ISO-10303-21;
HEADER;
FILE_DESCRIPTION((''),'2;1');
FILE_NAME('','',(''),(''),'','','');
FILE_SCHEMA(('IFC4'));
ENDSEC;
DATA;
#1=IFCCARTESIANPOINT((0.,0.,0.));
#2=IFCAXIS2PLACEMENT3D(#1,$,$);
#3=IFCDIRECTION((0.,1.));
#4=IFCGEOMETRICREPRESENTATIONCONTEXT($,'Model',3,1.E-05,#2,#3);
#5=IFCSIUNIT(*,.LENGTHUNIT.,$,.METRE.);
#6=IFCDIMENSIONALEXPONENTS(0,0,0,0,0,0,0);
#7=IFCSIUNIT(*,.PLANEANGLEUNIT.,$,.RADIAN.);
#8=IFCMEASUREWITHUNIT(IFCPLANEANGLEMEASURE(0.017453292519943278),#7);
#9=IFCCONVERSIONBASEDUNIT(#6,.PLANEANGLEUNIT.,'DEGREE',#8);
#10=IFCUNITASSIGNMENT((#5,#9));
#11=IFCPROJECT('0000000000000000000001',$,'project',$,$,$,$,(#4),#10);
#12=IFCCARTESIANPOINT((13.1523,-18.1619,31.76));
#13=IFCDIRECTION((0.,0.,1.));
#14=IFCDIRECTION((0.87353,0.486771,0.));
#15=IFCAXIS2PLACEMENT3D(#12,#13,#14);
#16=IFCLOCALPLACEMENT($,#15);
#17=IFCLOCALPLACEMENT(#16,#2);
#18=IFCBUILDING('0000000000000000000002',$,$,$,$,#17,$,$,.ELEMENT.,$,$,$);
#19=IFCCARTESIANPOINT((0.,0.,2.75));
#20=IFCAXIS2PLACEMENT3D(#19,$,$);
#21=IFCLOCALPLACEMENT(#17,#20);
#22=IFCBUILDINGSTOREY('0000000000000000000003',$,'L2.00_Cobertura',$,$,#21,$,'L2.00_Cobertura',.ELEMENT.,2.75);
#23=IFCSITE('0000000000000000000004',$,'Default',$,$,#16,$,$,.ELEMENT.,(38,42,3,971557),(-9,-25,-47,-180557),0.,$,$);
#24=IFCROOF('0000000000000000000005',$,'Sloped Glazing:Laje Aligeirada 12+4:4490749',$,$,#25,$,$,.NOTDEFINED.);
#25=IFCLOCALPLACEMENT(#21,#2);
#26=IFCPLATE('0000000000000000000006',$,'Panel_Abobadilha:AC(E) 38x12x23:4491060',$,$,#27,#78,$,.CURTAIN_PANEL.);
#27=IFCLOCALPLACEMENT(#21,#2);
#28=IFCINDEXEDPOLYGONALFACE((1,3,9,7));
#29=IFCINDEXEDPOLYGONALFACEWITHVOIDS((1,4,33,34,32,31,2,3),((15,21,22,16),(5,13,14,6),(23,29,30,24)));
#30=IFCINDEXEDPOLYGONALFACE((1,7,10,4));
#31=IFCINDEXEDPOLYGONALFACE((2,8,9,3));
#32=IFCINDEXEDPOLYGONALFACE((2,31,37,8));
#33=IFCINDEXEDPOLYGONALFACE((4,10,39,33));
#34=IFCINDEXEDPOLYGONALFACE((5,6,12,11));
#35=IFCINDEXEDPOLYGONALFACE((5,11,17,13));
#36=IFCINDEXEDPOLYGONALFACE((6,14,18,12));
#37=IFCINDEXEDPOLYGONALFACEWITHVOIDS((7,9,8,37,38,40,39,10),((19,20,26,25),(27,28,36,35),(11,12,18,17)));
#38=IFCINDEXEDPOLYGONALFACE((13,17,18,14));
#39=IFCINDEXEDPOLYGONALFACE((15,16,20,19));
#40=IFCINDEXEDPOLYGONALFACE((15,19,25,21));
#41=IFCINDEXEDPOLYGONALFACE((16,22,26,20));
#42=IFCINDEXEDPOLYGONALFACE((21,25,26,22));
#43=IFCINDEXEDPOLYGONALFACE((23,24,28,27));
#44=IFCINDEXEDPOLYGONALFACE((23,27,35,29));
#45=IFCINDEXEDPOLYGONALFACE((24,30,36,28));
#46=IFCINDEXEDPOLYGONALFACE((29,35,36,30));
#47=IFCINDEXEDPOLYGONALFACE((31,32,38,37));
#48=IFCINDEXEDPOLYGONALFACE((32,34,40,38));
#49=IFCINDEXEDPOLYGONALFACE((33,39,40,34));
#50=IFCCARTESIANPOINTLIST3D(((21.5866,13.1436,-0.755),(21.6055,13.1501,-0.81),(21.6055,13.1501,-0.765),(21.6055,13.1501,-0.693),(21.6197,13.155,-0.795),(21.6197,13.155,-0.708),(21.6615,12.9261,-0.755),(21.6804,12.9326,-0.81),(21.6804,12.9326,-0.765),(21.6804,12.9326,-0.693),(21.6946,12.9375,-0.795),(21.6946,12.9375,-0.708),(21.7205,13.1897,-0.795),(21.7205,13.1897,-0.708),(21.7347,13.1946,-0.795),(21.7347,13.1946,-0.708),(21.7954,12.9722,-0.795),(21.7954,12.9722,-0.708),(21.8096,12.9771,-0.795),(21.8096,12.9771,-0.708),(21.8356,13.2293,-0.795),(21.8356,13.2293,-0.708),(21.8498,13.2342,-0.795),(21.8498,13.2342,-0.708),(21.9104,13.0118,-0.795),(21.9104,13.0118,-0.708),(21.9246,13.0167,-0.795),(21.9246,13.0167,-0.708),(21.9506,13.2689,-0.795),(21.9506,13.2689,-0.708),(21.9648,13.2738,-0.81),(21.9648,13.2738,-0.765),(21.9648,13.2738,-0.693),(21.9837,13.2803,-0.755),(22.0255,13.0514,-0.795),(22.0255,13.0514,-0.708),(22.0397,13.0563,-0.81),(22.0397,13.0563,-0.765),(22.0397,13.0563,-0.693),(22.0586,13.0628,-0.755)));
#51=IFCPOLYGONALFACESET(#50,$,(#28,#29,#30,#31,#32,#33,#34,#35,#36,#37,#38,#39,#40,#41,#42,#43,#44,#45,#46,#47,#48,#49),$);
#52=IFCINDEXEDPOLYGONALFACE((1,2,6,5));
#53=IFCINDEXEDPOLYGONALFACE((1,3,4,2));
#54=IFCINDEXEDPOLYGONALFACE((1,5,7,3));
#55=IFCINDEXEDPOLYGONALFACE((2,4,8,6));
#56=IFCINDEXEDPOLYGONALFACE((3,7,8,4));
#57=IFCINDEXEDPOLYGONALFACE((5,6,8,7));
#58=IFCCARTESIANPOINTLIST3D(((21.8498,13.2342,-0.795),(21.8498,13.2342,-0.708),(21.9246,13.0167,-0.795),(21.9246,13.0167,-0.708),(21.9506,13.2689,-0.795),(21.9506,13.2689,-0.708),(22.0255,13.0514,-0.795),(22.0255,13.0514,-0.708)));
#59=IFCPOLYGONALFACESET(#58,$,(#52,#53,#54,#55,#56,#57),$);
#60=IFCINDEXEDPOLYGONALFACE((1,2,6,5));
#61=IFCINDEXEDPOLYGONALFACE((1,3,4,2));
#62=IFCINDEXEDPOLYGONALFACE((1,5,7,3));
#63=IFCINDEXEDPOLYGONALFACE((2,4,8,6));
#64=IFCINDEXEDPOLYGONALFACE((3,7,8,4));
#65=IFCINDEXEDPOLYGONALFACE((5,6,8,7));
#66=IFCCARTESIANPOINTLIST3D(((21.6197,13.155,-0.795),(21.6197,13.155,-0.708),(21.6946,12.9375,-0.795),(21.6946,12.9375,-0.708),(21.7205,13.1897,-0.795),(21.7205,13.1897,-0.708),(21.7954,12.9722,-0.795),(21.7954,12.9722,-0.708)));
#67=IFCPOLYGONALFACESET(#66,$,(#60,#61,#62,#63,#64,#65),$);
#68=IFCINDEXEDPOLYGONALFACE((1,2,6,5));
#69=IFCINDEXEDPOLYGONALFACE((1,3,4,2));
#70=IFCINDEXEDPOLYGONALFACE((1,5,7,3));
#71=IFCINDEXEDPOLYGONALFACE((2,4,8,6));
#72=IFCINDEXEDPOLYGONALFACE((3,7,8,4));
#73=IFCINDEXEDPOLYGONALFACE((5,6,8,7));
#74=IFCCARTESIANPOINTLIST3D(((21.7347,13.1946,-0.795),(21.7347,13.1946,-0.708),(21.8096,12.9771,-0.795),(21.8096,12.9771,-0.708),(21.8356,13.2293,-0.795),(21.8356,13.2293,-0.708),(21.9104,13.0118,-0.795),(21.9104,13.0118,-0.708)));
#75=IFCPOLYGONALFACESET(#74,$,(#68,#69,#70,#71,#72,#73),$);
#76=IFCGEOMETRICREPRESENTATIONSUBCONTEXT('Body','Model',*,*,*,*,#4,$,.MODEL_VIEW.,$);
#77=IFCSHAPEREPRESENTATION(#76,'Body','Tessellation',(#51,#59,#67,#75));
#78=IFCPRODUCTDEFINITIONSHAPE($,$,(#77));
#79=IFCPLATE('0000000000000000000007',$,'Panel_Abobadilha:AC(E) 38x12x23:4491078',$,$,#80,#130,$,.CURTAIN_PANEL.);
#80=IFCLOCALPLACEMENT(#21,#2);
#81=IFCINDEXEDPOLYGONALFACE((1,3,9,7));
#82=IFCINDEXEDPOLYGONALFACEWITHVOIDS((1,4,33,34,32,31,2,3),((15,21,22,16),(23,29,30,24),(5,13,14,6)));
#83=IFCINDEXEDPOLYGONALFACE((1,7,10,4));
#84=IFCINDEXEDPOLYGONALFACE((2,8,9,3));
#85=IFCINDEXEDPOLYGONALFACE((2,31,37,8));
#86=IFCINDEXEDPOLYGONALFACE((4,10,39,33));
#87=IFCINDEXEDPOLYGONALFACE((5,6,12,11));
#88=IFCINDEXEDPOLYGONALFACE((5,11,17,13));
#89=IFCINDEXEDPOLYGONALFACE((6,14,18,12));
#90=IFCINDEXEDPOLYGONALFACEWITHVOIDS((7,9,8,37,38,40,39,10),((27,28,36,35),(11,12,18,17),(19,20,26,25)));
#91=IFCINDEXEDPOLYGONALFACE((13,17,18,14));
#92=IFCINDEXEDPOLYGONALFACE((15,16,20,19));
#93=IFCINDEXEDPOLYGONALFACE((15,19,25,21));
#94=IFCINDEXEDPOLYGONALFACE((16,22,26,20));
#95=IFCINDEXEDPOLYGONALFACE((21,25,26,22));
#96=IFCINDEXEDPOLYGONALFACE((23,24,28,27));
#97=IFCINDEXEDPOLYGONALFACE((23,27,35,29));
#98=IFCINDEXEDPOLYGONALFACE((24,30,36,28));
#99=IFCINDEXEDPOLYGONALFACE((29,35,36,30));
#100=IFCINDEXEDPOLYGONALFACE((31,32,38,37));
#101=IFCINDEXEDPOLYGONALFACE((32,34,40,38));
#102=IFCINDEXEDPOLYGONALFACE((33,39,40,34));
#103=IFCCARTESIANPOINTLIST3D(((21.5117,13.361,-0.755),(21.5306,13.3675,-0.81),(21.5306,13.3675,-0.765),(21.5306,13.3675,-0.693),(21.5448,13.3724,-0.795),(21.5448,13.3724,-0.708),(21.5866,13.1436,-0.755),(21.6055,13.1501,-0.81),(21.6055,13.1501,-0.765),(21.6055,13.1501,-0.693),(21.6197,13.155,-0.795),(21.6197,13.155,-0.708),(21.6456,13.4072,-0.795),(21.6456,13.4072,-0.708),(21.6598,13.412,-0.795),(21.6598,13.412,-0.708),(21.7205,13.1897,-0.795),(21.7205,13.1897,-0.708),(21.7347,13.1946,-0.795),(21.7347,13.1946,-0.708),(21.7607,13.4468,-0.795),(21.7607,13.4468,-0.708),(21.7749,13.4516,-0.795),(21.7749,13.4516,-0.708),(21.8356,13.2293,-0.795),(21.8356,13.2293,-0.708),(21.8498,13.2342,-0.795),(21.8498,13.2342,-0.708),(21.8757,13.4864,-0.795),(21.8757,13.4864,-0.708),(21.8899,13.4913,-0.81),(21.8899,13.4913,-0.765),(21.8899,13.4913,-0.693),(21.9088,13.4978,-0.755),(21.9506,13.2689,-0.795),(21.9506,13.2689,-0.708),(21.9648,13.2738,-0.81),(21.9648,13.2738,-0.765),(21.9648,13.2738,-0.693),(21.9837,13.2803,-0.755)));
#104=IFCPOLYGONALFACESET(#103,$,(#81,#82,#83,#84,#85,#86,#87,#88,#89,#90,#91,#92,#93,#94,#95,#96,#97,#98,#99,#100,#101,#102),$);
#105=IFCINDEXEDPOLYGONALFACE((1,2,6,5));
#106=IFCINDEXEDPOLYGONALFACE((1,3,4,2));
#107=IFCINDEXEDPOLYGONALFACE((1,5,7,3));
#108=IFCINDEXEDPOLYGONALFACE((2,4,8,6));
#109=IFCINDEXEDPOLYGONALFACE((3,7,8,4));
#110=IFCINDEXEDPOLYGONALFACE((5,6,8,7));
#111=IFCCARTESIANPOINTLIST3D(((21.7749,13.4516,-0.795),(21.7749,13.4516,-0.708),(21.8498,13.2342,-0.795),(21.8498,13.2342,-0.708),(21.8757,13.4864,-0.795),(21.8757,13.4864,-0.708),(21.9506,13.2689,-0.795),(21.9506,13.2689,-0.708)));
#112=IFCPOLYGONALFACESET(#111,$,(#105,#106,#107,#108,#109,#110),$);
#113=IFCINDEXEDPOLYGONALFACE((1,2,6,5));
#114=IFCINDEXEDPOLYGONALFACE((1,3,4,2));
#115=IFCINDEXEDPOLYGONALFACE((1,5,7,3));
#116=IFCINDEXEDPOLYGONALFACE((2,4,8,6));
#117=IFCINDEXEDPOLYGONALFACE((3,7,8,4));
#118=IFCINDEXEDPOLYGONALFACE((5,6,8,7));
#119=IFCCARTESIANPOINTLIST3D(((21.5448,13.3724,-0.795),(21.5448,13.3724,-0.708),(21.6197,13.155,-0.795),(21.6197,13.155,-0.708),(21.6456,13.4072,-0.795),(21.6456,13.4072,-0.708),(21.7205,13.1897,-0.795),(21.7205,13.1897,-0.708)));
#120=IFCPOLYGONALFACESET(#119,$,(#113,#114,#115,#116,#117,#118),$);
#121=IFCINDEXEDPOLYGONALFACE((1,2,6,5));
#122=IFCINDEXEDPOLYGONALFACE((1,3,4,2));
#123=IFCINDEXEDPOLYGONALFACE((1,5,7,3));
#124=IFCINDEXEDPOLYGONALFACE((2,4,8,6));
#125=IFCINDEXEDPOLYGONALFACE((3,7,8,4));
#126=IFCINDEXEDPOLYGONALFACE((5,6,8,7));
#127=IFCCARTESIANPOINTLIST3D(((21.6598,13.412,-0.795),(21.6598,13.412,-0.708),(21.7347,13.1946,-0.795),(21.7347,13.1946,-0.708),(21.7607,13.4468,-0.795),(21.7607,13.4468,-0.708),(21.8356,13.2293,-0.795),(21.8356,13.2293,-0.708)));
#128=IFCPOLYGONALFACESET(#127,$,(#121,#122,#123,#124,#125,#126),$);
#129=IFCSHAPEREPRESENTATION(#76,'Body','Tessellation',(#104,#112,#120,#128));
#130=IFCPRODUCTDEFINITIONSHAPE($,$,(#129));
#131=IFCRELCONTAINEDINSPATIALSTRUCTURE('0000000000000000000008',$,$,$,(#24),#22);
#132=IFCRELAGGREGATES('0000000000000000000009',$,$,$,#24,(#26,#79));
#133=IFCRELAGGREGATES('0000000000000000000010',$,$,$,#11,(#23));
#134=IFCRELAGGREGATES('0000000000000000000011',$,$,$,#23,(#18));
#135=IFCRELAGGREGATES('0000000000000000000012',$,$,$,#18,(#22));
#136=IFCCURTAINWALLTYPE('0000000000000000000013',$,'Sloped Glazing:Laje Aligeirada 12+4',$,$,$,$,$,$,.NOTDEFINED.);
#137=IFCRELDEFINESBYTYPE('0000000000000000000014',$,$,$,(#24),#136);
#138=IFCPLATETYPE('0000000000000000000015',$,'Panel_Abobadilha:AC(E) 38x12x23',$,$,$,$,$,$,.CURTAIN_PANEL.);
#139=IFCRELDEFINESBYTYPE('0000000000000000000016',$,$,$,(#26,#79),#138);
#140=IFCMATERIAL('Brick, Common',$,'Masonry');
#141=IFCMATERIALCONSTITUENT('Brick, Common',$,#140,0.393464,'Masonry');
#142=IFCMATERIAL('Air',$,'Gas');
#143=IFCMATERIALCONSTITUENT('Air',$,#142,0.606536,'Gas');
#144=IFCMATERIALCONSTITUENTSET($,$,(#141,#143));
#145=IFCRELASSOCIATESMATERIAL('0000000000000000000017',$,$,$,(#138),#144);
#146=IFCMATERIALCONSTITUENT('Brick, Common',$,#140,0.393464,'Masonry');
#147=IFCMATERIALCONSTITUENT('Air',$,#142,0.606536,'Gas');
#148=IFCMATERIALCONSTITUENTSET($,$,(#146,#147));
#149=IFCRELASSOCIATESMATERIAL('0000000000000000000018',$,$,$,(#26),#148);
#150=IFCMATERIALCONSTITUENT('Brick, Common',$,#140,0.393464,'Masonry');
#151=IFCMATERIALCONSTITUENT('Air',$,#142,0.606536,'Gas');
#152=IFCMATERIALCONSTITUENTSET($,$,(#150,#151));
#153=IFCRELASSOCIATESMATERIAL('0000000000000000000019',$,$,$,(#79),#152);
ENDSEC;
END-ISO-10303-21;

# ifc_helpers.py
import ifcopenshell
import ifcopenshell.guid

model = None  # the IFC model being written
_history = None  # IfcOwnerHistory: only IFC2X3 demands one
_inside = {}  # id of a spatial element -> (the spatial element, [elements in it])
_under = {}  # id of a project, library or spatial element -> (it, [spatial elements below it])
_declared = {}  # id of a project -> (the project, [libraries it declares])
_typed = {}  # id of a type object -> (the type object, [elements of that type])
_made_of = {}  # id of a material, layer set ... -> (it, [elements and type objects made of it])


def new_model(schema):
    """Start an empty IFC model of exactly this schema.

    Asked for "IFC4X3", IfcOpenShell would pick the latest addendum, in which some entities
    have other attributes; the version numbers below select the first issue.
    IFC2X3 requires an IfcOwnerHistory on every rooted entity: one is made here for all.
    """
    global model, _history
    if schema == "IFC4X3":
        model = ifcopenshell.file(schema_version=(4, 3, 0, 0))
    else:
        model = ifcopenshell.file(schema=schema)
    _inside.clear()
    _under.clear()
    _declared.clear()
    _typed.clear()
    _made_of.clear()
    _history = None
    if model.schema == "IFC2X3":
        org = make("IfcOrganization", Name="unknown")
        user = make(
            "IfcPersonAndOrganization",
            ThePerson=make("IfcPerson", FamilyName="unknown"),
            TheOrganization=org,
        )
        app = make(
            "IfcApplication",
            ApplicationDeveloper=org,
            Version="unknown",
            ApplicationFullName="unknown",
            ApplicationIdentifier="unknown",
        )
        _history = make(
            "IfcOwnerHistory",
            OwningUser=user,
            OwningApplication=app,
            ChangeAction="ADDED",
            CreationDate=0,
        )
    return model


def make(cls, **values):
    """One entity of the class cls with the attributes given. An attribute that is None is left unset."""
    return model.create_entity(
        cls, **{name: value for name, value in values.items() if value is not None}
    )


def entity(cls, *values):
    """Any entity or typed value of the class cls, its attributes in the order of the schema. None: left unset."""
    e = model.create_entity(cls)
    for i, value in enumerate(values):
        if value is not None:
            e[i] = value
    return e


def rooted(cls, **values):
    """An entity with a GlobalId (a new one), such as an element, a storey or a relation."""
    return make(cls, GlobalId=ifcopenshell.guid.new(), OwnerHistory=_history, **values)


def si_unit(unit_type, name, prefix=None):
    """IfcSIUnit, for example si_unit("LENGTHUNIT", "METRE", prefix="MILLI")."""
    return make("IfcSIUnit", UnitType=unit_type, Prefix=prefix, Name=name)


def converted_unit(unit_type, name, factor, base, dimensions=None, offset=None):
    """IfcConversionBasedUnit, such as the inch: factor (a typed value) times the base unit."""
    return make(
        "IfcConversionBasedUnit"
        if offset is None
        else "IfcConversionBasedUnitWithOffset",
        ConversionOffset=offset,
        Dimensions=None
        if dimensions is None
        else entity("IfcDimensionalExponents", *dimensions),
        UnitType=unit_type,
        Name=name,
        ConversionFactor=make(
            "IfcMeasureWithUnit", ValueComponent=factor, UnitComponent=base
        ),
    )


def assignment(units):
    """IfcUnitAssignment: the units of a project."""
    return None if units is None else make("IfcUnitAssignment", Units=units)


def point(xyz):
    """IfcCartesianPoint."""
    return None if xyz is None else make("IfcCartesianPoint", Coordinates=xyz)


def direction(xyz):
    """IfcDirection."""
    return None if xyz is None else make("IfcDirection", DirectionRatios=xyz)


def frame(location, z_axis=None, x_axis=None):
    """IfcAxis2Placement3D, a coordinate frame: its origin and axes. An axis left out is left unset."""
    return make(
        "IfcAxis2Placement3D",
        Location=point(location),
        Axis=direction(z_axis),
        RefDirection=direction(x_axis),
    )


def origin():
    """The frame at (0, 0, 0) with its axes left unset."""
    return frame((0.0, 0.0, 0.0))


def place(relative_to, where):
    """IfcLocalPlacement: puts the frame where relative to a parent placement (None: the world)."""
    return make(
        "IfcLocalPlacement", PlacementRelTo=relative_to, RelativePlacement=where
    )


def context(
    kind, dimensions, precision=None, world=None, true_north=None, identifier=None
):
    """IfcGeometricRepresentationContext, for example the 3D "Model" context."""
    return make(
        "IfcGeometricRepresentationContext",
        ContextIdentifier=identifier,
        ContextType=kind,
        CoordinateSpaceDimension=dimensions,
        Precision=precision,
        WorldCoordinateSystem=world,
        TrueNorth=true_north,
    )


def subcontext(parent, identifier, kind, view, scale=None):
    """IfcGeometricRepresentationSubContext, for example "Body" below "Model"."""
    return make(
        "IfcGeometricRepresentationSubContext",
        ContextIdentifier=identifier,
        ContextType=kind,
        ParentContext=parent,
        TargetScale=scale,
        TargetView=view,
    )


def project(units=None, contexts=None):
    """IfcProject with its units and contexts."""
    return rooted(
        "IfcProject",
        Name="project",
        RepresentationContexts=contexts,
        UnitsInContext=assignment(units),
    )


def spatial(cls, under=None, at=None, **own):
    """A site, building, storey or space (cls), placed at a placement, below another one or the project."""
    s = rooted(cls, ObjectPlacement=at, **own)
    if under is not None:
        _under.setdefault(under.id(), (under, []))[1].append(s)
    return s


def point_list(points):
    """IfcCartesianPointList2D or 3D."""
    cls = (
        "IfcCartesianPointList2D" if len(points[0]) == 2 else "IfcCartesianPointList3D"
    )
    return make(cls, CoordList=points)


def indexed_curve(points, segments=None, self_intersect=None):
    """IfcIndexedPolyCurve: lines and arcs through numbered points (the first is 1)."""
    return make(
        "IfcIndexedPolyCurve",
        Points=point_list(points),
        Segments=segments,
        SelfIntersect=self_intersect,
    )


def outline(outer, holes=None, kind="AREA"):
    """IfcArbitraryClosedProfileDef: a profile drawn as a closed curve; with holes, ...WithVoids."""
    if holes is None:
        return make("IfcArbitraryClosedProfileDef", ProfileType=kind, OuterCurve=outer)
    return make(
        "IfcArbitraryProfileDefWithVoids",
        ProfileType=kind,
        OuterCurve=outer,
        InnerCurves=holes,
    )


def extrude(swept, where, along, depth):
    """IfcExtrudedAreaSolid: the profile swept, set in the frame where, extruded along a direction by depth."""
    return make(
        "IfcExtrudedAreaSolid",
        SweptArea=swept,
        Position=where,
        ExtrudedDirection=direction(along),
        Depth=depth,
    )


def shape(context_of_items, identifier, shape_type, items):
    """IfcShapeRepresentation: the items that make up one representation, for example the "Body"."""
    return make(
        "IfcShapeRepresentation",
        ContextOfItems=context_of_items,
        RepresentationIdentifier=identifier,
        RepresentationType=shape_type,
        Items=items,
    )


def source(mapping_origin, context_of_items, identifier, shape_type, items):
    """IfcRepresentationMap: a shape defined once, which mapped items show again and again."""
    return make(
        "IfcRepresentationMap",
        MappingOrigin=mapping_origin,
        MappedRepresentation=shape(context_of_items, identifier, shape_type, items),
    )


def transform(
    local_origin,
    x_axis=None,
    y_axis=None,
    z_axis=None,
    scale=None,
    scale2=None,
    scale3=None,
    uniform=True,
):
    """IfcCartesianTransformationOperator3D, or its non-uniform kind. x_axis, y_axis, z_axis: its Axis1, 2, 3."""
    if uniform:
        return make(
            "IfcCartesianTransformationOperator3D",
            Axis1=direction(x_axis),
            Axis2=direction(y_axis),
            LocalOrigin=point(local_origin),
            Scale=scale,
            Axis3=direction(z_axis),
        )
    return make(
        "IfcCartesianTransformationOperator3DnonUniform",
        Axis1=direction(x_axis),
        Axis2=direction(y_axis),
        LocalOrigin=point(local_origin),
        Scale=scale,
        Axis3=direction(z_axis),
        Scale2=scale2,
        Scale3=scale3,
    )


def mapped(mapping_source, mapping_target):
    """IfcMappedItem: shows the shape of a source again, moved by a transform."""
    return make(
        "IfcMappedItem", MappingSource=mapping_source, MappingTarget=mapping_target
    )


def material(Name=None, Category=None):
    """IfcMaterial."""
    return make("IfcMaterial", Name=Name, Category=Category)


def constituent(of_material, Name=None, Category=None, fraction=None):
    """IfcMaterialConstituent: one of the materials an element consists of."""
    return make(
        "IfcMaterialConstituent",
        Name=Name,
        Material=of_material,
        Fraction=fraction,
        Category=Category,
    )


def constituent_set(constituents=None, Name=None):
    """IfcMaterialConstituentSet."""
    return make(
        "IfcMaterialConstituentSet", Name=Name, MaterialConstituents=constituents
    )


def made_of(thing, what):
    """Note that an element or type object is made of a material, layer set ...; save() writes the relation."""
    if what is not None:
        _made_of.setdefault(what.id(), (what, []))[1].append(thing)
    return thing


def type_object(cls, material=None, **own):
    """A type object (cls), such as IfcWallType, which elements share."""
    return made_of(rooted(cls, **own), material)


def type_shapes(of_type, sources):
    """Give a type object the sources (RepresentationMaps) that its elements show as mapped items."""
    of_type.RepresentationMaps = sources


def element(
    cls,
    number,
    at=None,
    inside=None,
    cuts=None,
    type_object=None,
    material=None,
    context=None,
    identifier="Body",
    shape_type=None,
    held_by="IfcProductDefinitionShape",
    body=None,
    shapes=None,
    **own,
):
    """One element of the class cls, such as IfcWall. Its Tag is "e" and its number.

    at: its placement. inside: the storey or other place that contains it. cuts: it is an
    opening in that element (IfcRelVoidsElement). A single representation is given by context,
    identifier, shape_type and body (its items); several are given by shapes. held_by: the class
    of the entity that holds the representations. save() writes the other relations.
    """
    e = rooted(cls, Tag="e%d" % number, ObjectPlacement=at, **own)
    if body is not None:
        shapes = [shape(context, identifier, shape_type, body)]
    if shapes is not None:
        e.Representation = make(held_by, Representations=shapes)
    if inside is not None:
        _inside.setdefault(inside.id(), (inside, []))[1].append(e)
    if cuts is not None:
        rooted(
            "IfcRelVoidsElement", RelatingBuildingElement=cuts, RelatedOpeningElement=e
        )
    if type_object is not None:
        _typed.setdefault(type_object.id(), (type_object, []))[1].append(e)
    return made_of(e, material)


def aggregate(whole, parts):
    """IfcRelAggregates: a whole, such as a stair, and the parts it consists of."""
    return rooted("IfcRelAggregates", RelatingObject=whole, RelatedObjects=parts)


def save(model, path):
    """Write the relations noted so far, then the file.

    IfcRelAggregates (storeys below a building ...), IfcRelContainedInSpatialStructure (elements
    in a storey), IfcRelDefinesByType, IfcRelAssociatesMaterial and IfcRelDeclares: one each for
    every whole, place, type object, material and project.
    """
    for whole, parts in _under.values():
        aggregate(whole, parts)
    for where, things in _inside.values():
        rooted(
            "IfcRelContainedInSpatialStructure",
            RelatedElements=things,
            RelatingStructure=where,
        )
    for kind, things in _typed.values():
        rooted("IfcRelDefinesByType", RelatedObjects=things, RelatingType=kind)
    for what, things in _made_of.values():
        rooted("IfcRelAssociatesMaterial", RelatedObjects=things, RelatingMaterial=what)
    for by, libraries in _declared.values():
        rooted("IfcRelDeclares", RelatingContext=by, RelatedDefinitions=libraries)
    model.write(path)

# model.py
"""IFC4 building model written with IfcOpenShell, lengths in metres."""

from ifc_helpers import new_model, entity, si_unit, converted_unit, direction, frame, origin, place, context, subcontext, project, spatial, indexed_curve, outline, extrude, source, transform, mapped, material, constituent, constituent_set, type_object, type_shapes, element, aggregate, save


model = new_model("IFC4")

# Units and contexts
model_context = context("Model", 3, precision=1e-05, world=origin(), true_north=direction((0.0, 1.0)))
body_context = subcontext(model_context, "Body", "Model", "MODEL_VIEW")
ifc_project = project(units=[si_unit("LENGTHUNIT", "METRE"), converted_unit("PLANEANGLEUNIT", "DEGREE", entity("IfcPlaneAngleMeasure", 0.017453292519943278), si_unit("PLANEANGLEUNIT", "RADIAN"), dimensions=[0, 0, 0, 0, 0, 0, 0])], contexts=[model_context])

# Site, building, storey
site_placement = place(None, frame((13.1523, -18.1619, 31.76), z_axis=(0.0, 0.0, 1.0), x_axis=(0.87353, 0.486771, 0.0)))
site = spatial("IfcSite", under=ifc_project, at=site_placement, Name="Default", CompositionType="ELEMENT", RefLatitude=(38, 42, 3, 971557), RefLongitude=(-9, -25, -47, -180557), RefElevation=0.0)
building_placement = place(site_placement, origin())
building = spatial("IfcBuilding", under=site, at=building_placement, CompositionType="ELEMENT")
storey_placement = place(building_placement, frame((0.0, 0.0, 2.75)))
storey = spatial("IfcBuildingStorey", under=building, at=storey_placement, Name="L2.00_Cobertura", LongName="L2.00_Cobertura", CompositionType="ELEMENT", Elevation=2.75)

# Roof, plates
curtain_wall_type = type_object("IfcCurtainWallType", Name="Sloped Glazing:Laje Aligeirada 12+4", PredefinedType="NOTDEFINED")
roof_placement = place(storey_placement, frame((0.0, 0.0, -2.75)))
roof = element("IfcRoof", 1, at=roof_placement, inside=storey, type_object=curtain_wall_type, Name="Sloped Glazing:Laje Aligeirada 12+4:4490749", PredefinedType="NOTDEFINED")
ifc_material_1 = material(Name="Brick, Common", Category="Masonry")
ifc_material_2 = material(Name="Air", Category="Gas")
ifc_constituent_1 = constituent(ifc_material_1, Name="Brick, Common", Category="Masonry", fraction=0.393464)
ifc_constituent_2 = constituent(ifc_material_2, Name="Air", Category="Gas", fraction=0.606536)
ifc_constituent_set_1 = constituent_set(constituents=[ifc_constituent_1, ifc_constituent_2])
plate_type = type_object("IfcPlateType", Name="Panel_Abobadilha:AC(E) 38x12x23", PredefinedType="CURTAIN_PANEL", material=ifc_constituent_set_1)
shared_shape_1 = source(origin(), body_context, "Body", "SweptSolid", [
    extrude(outline(indexed_curve([(-0.19, -0.0543), (0.19, -0.0543), (0.19, -0.0093), (0.21, 0.0007), (0.19, 0.0628), (-0.19, 0.0628), (-0.21, 0.0007), (-0.19, -0.0093), (-0.19, -0.0543)], self_intersect=False), holes=[indexed_curve([(-0.0683, 0.0477), (-0.0683, -0.0393), (-0.175, -0.0393), (-0.175, 0.0477), (-0.0683, 0.0477)], self_intersect=False), indexed_curve([(0.0533, 0.0477), (0.0533, -0.0393), (-0.0533, -0.0393), (-0.0533, 0.0477), (0.0533, 0.0477)], self_intersect=False), indexed_curve([(0.175, 0.0477), (0.175, -0.0393), (0.0683, -0.0393), (0.0683, 0.0477), (0.175, 0.0477)], self_intersect=False)]), frame((0.0, 0.0543, 0.0)), (0.0, 0.0, 1.0), 0.23),
    extrude(outline(indexed_curve([(-0.0533, -0.0435), (0.0533, -0.0435), (0.0533, 0.0435), (-0.0533, 0.0435), (-0.0533, -0.0435)], self_intersect=False)), frame((0.1217, 0.0585, 0.0), z_axis=(0.0, 0.0, 1.0), x_axis=(-1.0, 0.0, 0.0)), (0.0, 0.0, 1.0), 0.23),
    extrude(outline(indexed_curve([(-0.0533, -0.0435), (0.0533, -0.0435), (0.0533, 0.0435), (-0.0533, 0.0435), (-0.0533, -0.0435)], self_intersect=False)), frame((-0.1217, 0.0585, 0.0), z_axis=(0.0, 0.0, 1.0), x_axis=(-1.0, 0.0, 0.0)), (0.0, 0.0, 1.0), 0.23),
    extrude(outline(indexed_curve([(-0.0533, -0.0435), (0.0533, -0.0435), (0.0533, 0.0435), (-0.0533, 0.0435), (-0.0533, -0.0435)], self_intersect=False)), frame((0.0, 0.0585, 0.0), z_axis=(0.0, 0.0, 1.0), x_axis=(-1.0, 0.0, 0.0)), (0.0, 0.0, 1.0), 0.23),
])
type_shapes(plate_type, [shared_shape_1])
ifc_constituent_3 = constituent(ifc_material_1, Name="Brick, Common", Category="Masonry", fraction=0.393464)
ifc_constituent_4 = constituent(ifc_material_2, Name="Air", Category="Gas", fraction=0.606536)
ifc_constituent_set_2 = constituent_set(constituents=[ifc_constituent_3, ifc_constituent_4])
plate_1_placement = place(roof_placement, frame((21.7851, 13.2119, 1.94), z_axis=(0.325568, -0.945519, 0.0), x_axis=(0.945519, 0.325568, 0.0)))
plate_1 = element("IfcPlate", 2, at=plate_1_placement, type_object=plate_type, material=ifc_constituent_set_2, Name="Panel_Abobadilha:AC(E) 38x12x23:4491060", PredefinedType="CURTAIN_PANEL", context=body_context, shape_type="MappedRepresentation", body=[
    mapped(shared_shape_1, transform((0.0, 0.0, 0.0), scale=1.0)),
])
ifc_constituent_5 = constituent(ifc_material_1, Name="Brick, Common", Category="Masonry", fraction=0.393464)
ifc_constituent_6 = constituent(ifc_material_2, Name="Air", Category="Gas", fraction=0.606536)
ifc_constituent_set_3 = constituent_set(constituents=[ifc_constituent_5, ifc_constituent_6])
plate_2_placement = place(roof_placement, frame((21.7103, 13.4294, 1.94), z_axis=(0.325568, -0.945519, 0.0), x_axis=(0.945519, 0.325568, 0.0)))
plate_2 = element("IfcPlate", 3, at=plate_2_placement, type_object=plate_type, material=ifc_constituent_set_3, Name="Panel_Abobadilha:AC(E) 38x12x23:4491078", PredefinedType="CURTAIN_PANEL", context=body_context, shape_type="MappedRepresentation", body=[
    mapped(shared_shape_1, transform((0.0, 0.0, 0.0), scale=1.0)),
])
aggregate(roof, [plate_1, plate_2])

save(model, "model.ifc")
